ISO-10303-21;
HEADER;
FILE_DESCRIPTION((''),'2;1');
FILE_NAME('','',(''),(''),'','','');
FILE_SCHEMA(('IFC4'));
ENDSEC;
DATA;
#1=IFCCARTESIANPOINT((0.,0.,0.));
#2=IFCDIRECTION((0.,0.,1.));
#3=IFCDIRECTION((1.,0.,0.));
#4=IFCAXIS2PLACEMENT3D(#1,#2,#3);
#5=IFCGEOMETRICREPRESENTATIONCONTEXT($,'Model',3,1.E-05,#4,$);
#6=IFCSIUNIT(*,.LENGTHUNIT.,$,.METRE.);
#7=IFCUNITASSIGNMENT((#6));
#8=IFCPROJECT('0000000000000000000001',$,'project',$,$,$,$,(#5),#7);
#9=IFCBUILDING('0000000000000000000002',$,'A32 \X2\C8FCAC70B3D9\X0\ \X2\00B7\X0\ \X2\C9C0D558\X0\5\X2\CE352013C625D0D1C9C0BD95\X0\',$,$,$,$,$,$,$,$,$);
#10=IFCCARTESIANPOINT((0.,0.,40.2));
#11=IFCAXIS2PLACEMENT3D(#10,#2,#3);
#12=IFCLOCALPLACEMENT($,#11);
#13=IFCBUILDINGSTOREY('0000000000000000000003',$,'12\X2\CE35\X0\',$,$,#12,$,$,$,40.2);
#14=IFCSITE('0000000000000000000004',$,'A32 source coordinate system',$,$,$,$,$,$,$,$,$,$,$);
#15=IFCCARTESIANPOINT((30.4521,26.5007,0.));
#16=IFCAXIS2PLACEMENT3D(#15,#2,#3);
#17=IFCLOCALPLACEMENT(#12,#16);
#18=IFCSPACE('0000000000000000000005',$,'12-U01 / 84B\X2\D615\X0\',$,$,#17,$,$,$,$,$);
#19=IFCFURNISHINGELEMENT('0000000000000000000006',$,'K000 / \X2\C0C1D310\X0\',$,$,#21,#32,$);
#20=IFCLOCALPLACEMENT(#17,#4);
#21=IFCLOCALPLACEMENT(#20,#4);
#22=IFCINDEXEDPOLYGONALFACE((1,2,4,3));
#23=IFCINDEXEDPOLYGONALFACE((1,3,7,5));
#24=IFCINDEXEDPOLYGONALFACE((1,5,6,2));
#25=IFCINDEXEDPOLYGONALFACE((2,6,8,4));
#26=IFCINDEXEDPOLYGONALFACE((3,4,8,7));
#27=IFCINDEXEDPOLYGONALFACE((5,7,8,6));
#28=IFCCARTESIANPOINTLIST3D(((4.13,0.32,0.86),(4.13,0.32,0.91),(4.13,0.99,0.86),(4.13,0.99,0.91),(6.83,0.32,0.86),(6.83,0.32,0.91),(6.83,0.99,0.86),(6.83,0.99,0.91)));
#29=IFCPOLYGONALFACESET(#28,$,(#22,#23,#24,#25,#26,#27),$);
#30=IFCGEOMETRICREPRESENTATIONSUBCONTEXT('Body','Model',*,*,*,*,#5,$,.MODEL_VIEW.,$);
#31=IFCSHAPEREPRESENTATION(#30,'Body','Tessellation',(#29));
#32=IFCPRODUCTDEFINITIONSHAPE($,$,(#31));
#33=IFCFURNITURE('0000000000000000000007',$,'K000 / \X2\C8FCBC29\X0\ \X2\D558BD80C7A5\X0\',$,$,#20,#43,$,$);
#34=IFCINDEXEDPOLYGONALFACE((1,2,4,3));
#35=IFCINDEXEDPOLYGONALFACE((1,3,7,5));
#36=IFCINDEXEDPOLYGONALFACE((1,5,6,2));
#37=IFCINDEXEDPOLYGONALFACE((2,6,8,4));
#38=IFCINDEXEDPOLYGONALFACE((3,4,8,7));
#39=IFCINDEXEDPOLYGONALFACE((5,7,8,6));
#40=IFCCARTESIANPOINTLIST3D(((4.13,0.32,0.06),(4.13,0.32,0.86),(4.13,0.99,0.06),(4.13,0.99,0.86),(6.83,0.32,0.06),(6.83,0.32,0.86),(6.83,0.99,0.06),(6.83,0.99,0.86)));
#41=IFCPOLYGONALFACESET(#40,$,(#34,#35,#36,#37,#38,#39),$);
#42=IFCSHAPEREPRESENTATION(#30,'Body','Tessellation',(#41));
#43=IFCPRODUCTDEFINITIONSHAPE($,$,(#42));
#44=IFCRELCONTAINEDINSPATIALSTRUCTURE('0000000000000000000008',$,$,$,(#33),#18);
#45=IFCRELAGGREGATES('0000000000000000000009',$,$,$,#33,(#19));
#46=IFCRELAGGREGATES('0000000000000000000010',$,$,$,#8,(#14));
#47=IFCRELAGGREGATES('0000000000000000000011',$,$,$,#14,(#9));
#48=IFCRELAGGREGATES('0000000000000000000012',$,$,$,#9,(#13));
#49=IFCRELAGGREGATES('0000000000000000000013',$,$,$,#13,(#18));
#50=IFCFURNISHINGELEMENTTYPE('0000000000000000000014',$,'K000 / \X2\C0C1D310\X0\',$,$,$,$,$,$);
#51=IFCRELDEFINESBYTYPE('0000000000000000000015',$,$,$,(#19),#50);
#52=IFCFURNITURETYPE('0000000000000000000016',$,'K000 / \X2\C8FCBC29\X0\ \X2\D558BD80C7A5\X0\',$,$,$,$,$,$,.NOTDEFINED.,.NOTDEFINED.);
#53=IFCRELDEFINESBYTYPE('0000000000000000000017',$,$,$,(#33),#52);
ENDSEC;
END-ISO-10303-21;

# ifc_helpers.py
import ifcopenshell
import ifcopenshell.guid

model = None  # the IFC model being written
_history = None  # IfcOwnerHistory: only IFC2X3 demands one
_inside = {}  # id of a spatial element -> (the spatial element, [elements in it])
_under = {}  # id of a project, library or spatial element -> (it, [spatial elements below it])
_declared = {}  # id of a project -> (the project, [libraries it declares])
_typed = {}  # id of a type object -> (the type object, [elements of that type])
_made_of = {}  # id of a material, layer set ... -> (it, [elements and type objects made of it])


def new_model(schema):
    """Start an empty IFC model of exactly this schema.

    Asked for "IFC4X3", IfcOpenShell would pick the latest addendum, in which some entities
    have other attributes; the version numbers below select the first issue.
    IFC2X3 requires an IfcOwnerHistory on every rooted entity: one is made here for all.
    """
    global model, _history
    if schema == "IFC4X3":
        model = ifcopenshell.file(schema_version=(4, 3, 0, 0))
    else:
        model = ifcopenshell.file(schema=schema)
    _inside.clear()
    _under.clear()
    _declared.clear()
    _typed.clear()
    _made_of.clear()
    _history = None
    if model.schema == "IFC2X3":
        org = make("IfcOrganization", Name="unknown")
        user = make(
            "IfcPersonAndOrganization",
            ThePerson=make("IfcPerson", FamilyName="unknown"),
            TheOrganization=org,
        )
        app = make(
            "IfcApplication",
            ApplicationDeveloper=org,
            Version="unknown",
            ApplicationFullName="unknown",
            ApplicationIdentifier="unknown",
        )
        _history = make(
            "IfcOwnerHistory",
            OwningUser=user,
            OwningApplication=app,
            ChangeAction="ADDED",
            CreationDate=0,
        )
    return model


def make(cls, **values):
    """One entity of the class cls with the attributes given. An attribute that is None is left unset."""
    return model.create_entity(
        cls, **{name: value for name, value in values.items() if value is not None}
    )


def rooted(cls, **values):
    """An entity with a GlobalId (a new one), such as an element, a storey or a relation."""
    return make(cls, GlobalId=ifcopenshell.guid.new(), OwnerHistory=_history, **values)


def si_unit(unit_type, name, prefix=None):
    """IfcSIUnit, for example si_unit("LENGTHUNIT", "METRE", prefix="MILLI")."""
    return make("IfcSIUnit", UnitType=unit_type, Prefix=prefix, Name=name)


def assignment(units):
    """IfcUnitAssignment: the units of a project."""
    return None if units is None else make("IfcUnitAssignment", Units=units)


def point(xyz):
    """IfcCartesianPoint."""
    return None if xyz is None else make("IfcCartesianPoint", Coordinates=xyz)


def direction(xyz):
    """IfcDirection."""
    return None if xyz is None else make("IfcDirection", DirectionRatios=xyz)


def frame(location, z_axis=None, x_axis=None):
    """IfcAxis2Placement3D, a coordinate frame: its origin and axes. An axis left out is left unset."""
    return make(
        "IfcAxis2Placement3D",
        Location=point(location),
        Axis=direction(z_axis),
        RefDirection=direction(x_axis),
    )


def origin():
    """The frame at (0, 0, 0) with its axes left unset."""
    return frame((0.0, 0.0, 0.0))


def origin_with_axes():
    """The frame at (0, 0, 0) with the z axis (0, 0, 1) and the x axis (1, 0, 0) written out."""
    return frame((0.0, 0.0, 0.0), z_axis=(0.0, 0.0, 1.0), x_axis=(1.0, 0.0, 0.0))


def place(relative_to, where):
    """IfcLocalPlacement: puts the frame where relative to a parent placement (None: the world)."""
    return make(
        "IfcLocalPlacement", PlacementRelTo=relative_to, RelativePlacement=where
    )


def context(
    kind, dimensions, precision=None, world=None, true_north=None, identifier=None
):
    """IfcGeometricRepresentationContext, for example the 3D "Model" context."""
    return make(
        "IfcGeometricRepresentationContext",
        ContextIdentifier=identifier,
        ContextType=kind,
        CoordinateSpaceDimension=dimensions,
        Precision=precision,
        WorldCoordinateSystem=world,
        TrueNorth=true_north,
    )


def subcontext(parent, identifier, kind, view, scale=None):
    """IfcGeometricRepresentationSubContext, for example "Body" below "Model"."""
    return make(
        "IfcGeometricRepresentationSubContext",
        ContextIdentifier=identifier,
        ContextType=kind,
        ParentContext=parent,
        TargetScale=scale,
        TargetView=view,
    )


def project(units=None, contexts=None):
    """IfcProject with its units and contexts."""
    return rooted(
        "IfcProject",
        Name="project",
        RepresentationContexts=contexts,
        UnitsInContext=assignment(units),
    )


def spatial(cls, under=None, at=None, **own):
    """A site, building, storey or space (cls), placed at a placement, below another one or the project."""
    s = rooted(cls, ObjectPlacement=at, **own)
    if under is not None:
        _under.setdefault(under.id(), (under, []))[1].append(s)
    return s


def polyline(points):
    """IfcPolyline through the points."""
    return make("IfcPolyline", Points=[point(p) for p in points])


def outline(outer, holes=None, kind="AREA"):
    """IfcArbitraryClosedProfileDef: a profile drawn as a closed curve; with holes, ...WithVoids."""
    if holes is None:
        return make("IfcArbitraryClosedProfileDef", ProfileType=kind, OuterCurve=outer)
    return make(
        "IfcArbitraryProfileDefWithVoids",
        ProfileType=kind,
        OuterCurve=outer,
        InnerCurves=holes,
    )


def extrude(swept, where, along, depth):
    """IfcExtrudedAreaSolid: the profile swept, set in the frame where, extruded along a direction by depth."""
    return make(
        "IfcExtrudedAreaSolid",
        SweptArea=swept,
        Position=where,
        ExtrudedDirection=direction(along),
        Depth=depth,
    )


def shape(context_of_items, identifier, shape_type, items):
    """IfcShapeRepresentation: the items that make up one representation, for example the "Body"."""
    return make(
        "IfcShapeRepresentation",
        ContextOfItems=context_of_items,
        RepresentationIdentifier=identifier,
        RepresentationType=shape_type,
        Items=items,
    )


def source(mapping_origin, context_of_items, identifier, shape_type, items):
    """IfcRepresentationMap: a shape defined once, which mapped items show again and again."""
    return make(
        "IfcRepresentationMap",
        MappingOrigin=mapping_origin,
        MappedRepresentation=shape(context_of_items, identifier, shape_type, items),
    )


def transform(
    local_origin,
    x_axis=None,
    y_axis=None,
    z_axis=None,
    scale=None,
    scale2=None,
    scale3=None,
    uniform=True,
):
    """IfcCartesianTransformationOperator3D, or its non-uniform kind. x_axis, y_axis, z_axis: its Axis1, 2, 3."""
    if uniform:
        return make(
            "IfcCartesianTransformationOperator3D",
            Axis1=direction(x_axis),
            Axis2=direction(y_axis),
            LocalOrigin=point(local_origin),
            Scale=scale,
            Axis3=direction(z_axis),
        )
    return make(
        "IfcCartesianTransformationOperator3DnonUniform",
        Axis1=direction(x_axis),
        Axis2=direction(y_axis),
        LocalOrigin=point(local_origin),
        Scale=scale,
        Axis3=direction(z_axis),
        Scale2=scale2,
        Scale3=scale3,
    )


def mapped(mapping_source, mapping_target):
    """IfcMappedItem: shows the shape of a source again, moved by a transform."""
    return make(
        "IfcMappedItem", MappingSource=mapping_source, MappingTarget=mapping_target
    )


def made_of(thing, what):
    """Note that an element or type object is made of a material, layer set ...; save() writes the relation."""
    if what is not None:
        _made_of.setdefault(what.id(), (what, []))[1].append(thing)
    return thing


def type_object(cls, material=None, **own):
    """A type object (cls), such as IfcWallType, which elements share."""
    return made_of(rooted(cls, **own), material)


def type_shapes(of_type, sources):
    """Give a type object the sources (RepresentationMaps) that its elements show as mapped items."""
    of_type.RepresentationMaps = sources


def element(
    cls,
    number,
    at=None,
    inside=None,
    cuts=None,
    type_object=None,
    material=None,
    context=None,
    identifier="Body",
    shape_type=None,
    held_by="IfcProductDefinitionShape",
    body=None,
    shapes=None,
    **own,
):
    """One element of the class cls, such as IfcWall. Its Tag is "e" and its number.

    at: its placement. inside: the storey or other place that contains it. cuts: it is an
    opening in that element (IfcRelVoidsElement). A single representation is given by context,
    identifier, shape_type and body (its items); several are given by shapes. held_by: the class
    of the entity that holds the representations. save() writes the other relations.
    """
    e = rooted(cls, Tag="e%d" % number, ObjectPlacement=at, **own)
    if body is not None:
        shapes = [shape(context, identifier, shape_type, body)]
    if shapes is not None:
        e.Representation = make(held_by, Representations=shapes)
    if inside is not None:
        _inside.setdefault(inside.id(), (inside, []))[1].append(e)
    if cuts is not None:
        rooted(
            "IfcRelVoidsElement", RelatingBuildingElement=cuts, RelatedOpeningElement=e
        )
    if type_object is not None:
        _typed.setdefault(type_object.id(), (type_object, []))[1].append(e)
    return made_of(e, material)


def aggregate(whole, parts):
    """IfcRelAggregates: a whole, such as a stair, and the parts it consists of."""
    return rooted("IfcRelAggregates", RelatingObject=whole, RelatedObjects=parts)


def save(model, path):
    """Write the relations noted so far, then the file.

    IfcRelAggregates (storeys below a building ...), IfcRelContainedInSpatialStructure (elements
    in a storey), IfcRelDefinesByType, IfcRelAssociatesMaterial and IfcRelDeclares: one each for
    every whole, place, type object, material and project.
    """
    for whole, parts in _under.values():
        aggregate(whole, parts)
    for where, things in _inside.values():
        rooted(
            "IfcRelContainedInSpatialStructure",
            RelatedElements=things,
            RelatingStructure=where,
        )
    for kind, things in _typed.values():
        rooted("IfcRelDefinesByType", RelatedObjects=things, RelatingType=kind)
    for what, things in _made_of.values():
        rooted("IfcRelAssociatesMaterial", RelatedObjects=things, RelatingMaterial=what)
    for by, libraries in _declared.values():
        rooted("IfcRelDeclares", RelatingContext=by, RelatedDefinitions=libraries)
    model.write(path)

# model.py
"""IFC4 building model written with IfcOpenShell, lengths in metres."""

from ifc_helpers import new_model, si_unit, frame, origin, origin_with_axes, place, context, subcontext, project, spatial, polyline, outline, extrude, source, transform, mapped, type_object, type_shapes, element, aggregate, save


model = new_model("IFC4")

# Units and contexts
model_context = context("Model", 3, precision=1e-05, world=origin_with_axes())
body_context = subcontext(model_context, "Body", "Model", "MODEL_VIEW")
ifc_project = project(units=[si_unit("LENGTHUNIT", "METRE")], contexts=[model_context])

# Site, building, storey, space
site = spatial("IfcSite", under=ifc_project, Name="A32 source coordinate system")
building = spatial("IfcBuilding", under=site, Name="A32 주거동 · 지하5층–옥탑지붕")
storey_placement = place(None, frame((0.0, 0.0, 40.2), z_axis=(0.0, 0.0, 1.0), x_axis=(1.0, 0.0, 0.0)))
storey = spatial("IfcBuildingStorey", under=building, at=storey_placement, Name="12층", Elevation=40.2)
space_placement = place(storey_placement, frame((30.4521, 26.5007, 0.0), z_axis=(0.0, 0.0, 1.0), x_axis=(1.0, 0.0, 0.0)))
space = spatial("IfcSpace", under=storey, at=space_placement, Name="12-U01 / 84B형")

# Furnishing element
furnishing_element_type = type_object("IfcFurnishingElementType", Name="K000 / 상판")
shared_shape_1 = source(origin(), body_context, "Body", "SweptSolid", [
    extrude(outline(polyline([(4.13, 0.32), (4.13, 0.99), (6.83, 0.99), (6.83, 0.32), (4.13, 0.32)])), frame((0.0, 0.0, 0.86)), (0.0, 0.0, 1.0), 0.05),
])
type_shapes(furnishing_element_type, [shared_shape_1])
furniture_placement = place(space_placement, origin_with_axes())
furnishing_placement = place(furniture_placement, origin_with_axes())
furnishing = element("IfcFurnishingElement", 1, at=furnishing_placement, type_object=furnishing_element_type, Name="K000 / 상판", context=body_context, shape_type="MappedRepresentation", body=[
    mapped(shared_shape_1, transform((0.0, 0.0, 0.0), scale=1.0)),
])

# Furniture
furniture_type = type_object("IfcFurnitureType", Name="K000 / 주방 하부장", AssemblyPlace="NOTDEFINED", PredefinedType="NOTDEFINED")
shared_shape_2 = source(origin(), body_context, "Body", "SweptSolid", [
    extrude(outline(polyline([(6.83, 0.32), (4.13, 0.32), (4.13, 0.99), (6.83, 0.99), (6.83, 0.32)])), frame((0.0, 0.0, 0.06)), (0.0, 0.0, 1.0), 0.8),
])
type_shapes(furniture_type, [shared_shape_2])
furniture = element("IfcFurniture", 2, at=furniture_placement, inside=space, type_object=furniture_type, Name="K000 / 주방 하부장", context=body_context, shape_type="MappedRepresentation", body=[
    mapped(shared_shape_2, transform((0.0, 0.0, 0.0), scale=1.0)),
])
aggregate(furniture, [furnishing])

save(model, "model.ifc")
